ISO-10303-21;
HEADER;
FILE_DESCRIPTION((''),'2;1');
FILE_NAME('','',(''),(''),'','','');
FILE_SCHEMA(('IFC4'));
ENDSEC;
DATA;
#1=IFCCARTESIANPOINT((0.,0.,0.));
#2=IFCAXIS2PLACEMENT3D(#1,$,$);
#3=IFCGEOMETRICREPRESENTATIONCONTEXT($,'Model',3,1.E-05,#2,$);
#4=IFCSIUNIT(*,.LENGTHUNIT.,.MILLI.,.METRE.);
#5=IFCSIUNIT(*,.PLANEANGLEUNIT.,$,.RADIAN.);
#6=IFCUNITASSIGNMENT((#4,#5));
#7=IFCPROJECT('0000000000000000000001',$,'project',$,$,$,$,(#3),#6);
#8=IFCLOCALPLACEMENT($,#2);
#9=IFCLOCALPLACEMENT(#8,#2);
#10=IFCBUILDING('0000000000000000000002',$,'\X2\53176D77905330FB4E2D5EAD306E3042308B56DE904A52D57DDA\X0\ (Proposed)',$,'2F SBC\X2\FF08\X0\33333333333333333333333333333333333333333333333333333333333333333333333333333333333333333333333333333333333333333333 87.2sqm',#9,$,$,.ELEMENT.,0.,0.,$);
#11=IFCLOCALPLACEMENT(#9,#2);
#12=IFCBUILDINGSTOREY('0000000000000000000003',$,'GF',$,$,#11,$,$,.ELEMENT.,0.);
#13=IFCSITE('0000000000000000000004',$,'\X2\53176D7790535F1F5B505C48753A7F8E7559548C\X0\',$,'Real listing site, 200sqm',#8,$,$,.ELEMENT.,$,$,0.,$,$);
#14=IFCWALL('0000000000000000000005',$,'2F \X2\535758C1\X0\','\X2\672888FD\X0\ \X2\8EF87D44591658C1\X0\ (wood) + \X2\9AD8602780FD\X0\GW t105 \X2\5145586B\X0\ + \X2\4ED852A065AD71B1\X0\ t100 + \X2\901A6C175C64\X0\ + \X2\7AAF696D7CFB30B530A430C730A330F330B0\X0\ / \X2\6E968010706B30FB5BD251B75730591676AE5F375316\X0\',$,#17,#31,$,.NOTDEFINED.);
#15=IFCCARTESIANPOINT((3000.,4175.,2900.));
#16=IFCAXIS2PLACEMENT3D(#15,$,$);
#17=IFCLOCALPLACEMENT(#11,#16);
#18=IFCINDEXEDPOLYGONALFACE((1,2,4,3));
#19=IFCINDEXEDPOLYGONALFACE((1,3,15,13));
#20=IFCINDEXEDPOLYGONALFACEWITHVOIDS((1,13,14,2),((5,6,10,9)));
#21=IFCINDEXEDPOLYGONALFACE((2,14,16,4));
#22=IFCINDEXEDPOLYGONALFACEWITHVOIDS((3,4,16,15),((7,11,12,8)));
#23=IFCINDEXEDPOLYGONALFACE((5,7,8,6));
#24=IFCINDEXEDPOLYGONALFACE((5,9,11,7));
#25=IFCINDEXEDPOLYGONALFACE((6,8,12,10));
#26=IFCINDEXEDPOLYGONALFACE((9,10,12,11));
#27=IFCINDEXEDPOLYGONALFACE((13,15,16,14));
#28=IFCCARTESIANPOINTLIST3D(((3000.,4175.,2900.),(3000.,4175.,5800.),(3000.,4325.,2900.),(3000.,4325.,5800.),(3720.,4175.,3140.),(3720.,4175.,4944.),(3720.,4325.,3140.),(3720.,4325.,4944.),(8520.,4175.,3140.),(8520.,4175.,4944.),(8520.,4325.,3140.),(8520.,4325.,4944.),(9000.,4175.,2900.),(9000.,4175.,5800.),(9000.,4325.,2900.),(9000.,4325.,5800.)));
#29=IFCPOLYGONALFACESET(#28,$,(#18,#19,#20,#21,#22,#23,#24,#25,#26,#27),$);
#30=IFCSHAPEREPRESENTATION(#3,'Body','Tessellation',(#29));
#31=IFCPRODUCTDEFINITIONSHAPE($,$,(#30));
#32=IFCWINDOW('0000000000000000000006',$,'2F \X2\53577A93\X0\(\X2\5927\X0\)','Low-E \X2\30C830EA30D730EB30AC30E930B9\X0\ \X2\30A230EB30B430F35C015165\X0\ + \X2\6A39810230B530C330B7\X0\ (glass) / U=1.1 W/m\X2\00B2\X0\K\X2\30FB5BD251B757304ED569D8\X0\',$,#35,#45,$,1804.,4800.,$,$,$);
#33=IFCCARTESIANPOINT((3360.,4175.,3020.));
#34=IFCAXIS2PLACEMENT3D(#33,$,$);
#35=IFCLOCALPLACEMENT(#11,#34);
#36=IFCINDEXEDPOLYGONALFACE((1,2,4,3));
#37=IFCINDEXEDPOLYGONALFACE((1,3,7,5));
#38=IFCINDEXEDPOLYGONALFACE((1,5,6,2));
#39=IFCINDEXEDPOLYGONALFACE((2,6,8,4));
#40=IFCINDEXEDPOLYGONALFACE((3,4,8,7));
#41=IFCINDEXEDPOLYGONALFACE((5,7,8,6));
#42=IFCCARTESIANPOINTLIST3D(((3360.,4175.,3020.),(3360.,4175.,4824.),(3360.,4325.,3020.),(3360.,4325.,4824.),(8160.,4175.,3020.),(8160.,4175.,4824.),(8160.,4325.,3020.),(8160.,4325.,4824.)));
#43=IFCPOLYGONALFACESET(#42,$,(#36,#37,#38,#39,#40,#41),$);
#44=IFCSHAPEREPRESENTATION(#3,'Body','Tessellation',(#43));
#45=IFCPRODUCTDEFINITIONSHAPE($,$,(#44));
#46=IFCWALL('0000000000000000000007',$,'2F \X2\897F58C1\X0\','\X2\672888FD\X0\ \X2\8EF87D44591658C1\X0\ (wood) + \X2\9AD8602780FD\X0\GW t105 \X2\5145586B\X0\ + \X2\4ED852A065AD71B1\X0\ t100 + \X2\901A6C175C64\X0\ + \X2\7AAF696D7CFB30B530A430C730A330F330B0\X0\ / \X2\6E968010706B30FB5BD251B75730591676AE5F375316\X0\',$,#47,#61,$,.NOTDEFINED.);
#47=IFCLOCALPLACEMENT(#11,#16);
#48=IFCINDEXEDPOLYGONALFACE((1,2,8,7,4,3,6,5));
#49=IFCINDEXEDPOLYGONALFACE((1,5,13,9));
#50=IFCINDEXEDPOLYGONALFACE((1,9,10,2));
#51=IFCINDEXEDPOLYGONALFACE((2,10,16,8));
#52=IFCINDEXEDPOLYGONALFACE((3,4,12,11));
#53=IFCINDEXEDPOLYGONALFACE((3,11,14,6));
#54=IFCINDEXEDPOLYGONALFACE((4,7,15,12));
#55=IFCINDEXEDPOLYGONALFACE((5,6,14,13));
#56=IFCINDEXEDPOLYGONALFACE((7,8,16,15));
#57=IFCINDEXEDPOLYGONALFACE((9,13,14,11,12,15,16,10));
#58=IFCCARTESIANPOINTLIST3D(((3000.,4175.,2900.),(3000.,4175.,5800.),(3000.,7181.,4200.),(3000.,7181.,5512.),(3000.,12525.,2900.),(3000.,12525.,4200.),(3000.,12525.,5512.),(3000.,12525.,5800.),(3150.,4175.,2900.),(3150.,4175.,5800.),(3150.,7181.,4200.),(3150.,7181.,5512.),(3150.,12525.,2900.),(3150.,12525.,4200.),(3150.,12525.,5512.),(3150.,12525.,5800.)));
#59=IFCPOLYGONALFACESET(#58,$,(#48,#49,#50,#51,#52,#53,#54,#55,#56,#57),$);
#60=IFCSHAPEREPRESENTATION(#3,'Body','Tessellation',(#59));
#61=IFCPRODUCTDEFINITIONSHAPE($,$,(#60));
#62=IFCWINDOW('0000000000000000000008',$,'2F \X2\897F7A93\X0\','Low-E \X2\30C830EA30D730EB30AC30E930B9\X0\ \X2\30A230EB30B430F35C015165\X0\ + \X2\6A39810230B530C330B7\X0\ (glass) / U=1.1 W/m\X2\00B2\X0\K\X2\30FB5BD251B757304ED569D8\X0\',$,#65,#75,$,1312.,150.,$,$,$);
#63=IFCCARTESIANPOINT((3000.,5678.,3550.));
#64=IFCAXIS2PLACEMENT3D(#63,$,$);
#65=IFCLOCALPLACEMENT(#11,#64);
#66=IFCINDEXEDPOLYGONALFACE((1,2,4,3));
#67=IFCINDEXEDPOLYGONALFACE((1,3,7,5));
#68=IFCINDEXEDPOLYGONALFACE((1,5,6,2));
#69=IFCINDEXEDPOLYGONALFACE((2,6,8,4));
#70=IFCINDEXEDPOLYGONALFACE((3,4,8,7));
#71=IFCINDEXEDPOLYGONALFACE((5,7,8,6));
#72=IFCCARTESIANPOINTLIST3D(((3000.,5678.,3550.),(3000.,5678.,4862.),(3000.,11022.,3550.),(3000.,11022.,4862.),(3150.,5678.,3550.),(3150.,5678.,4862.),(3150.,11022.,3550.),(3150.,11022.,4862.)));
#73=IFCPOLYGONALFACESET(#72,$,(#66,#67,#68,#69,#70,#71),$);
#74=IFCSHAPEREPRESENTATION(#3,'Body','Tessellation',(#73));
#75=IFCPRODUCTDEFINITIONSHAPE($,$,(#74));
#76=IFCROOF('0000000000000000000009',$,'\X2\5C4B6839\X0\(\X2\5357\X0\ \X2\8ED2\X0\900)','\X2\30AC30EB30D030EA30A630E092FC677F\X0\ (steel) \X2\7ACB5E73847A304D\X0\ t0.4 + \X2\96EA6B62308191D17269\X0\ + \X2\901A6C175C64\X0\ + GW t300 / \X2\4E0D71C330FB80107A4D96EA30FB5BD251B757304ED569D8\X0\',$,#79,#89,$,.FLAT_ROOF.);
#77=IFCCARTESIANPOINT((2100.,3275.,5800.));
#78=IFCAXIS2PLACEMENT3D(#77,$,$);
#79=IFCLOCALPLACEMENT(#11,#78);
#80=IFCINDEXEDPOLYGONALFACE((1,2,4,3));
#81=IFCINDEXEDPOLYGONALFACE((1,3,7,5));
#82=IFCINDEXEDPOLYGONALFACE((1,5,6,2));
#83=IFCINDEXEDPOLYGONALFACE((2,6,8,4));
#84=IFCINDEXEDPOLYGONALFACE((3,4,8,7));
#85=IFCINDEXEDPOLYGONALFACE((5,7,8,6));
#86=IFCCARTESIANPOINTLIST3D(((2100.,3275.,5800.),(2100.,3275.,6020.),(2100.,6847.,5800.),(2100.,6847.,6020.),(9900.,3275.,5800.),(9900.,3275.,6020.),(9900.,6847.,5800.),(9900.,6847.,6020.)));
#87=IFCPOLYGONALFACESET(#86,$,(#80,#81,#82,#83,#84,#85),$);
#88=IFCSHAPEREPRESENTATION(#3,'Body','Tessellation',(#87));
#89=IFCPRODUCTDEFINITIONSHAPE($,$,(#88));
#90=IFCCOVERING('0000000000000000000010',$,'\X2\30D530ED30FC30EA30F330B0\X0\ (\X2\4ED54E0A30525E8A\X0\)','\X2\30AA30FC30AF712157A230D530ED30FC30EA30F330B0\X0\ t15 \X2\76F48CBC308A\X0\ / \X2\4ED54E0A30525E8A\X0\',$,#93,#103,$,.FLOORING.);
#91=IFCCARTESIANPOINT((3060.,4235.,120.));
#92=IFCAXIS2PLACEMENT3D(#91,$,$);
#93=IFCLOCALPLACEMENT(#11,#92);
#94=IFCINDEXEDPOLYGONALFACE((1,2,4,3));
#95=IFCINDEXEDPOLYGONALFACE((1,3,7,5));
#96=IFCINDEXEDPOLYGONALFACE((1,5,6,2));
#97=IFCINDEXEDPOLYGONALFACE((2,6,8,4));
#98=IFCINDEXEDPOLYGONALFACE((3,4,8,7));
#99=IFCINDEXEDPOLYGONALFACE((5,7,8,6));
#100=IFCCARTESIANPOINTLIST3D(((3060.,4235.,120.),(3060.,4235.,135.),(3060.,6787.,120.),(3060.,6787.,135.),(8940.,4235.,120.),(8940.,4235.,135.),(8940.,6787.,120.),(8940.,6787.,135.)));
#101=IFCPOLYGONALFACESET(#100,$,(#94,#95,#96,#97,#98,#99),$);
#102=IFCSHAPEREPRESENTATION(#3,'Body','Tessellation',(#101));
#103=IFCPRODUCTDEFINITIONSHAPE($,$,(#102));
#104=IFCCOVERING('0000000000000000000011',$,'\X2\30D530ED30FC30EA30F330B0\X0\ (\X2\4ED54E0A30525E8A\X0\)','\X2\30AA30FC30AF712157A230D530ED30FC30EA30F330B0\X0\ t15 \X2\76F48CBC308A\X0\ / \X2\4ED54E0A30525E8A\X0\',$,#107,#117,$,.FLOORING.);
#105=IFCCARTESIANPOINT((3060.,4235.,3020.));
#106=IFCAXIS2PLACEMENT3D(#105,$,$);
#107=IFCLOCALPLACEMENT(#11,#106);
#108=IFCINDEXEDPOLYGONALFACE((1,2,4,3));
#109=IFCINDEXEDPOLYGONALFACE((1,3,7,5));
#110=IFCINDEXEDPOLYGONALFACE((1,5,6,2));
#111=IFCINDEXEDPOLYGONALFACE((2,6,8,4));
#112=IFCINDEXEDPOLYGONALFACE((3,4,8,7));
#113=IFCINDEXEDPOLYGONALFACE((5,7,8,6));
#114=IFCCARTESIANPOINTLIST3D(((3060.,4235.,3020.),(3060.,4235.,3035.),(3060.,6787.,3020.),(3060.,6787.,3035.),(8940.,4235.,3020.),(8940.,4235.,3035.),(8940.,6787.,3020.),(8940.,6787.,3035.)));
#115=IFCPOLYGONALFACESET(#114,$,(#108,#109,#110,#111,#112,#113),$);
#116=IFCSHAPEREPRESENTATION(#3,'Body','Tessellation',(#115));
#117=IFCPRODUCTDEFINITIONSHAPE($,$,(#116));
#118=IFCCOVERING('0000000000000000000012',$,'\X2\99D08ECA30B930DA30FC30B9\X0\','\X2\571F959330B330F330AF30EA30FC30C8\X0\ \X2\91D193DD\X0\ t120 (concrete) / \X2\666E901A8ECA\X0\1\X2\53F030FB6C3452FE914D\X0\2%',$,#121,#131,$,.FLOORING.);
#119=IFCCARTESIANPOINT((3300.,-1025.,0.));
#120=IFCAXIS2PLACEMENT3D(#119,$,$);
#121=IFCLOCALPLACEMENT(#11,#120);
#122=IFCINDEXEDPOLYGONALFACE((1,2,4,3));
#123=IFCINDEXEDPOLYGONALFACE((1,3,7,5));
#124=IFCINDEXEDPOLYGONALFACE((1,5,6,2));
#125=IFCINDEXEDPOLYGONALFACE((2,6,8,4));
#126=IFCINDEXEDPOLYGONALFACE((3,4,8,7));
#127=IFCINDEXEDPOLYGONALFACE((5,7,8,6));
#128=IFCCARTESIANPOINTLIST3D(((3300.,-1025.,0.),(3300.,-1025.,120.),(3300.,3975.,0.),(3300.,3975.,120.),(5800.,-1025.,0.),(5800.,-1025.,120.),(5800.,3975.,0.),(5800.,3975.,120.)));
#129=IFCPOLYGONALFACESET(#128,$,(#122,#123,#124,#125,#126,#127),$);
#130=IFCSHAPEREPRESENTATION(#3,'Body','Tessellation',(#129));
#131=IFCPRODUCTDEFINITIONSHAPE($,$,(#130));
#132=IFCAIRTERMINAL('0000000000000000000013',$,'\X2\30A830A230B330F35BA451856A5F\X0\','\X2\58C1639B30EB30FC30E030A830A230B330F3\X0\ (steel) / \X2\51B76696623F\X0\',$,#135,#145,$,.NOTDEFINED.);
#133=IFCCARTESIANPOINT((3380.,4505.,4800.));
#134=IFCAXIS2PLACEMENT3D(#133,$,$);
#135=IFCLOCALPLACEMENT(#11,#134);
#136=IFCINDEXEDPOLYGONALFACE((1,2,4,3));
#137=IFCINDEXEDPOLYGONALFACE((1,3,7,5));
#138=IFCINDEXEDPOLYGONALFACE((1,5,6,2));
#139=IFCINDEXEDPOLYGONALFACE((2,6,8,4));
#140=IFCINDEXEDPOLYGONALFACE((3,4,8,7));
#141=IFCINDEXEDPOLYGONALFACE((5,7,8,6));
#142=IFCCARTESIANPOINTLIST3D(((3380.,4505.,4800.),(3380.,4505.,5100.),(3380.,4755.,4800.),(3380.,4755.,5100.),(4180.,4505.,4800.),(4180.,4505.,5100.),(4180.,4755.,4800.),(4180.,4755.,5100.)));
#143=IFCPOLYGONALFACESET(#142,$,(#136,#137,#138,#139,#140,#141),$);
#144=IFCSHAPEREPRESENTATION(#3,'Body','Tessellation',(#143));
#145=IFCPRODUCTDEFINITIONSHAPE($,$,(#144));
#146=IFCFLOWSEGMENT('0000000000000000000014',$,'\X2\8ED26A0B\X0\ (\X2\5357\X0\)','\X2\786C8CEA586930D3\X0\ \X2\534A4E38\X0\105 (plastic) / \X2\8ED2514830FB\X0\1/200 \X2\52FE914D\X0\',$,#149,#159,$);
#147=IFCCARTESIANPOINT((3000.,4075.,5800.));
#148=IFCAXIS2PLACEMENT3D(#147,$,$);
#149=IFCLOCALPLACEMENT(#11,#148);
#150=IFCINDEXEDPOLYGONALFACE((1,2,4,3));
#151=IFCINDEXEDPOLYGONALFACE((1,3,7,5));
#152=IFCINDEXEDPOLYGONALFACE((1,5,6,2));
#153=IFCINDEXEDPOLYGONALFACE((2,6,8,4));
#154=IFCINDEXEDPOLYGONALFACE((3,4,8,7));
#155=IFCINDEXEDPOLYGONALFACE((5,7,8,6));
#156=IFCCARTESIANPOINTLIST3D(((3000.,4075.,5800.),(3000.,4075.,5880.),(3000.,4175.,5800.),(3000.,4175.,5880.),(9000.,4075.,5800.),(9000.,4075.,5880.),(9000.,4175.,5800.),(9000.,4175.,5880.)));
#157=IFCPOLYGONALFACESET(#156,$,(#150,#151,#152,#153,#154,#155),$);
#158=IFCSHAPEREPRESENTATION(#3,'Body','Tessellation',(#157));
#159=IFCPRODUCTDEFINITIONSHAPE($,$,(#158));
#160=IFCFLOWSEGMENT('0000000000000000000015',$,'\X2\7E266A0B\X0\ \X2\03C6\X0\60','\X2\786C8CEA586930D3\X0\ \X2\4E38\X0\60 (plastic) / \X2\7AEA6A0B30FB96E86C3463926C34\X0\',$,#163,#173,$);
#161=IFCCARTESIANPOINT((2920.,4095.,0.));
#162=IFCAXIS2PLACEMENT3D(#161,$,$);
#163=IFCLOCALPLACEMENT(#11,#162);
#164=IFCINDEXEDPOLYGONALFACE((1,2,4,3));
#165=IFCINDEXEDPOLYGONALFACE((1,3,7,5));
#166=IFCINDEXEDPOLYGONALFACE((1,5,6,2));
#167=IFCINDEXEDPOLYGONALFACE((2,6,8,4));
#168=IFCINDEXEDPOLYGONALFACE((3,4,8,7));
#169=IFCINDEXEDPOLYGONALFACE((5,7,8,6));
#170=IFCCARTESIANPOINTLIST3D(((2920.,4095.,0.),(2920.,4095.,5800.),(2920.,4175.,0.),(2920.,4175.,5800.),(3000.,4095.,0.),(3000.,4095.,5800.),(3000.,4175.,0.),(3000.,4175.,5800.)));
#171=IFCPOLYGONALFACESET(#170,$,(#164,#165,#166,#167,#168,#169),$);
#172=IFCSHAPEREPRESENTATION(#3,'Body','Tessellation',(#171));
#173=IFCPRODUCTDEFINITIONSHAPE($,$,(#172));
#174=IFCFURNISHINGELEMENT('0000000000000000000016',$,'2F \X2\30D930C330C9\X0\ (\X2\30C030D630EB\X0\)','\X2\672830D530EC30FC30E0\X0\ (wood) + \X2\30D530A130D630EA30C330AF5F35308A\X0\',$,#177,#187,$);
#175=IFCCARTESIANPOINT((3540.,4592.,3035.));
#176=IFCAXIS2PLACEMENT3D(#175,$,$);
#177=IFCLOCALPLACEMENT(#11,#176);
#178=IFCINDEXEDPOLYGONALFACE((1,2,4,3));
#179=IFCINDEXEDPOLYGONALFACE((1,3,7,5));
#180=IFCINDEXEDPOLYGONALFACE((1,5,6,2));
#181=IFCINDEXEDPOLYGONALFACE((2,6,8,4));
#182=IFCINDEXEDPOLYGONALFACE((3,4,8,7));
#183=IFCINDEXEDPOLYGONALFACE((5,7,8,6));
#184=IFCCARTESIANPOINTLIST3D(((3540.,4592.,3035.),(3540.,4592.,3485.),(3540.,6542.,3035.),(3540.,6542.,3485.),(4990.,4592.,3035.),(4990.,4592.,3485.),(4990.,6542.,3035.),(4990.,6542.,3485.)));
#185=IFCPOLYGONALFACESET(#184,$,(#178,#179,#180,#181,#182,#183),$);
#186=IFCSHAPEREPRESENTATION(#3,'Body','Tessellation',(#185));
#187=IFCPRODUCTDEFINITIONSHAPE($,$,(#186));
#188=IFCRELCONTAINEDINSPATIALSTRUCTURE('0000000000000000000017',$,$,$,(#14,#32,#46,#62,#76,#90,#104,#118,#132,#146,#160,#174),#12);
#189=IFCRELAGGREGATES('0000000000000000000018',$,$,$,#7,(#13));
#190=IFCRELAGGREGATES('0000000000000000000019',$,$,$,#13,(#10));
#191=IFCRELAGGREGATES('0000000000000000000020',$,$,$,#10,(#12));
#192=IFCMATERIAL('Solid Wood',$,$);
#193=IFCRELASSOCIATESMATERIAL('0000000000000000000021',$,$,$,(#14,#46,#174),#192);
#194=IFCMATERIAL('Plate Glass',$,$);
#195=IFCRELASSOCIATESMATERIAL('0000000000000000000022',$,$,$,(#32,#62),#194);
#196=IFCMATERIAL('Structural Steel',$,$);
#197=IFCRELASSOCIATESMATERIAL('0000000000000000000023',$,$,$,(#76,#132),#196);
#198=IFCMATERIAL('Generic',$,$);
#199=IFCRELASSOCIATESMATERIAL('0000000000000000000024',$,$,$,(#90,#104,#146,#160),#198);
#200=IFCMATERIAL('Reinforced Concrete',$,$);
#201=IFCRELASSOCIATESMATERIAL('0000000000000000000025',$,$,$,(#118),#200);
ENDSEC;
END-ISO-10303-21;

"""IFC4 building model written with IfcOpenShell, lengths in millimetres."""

from ifc_helpers import new_model, si_unit, frame, frame_2d, origin, place, context, project, spatial, rectangle, extrude, material, element, fill, save


model = new_model("IFC4")

# Units and contexts
model_context = context("Model", 3, precision=1e-05, world=origin())
ifc_project = project(units=[si_unit("LENGTHUNIT", "METRE", prefix="MILLI"), si_unit("PLANEANGLEUNIT", "RADIAN")], contexts=[model_context])

# Site, building, storey
site_placement = place(None, origin())
site = spatial("IfcSite", under=ifc_project, at=site_placement, Name="北海道弟子屈町美留和", ObjectType="Real listing site, 200sqm", CompositionType="ELEMENT", RefElevation=0.0)
building_placement = place(site_placement, origin())
building = spatial("IfcBuilding", under=site, at=building_placement, Name="北海道・中庭のある回遊動線 (Proposed)", ObjectType="2F SBC（33333333333333333333333333333333333333333333333333333333333333333333333333333333333333333333333333333333333333333333 87.2sqm", CompositionType="ELEMENT", ElevationOfRefHeight=0.0, ElevationOfTerrain=0.0)
storey_placement = place(building_placement, origin())
storey = spatial("IfcBuildingStorey", under=building, at=storey_placement, Name="GF", CompositionType="ELEMENT", Elevation=0.0)

# Shared definitions
ifc_material_1 = material(Name="Solid Wood")

# Shared definitions
ifc_material_2 = material(Name="Reinforced Concrete")

# Shared definitions
ifc_material_3 = material(Name="Plate Glass")

# Walls, openings, windows
wall_1_placement = place(storey_placement, frame((3000.0, 4175.0, 2900.0)))
wall_1 = element("IfcWall", 1, at=wall_1_placement, inside=storey, material=ifc_material_1, Name="2F 南壁", Description="木製 軸組外壁 (wood) + 高性能GW t105 充填 + 付加断熱 t100 + 通気層 + 窯業系サイディング / 準耐火・寒冷地外皮強化", PredefinedType="NOTDEFINED", context=model_context, shape_type="SweptSolid", body=[
    extrude(rectangle(XDim=6000.0, YDim=150.0, at=frame_2d((3000.0, 75.0))), frame((3000.0, 4175.0, 2900.0)), (0.0, 0.0, 1.0), 2900.0),
])
opening_1_placement = place(storey_placement, frame((3360.0, 4175.0, 3020.0)))
opening_1 = element("IfcOpeningElement", 2, at=opening_1_placement, cuts=wall_1, PredefinedType="NOTDEFINED", context=model_context, shape_type="SweptSolid", body=[
    extrude(rectangle(XDim=4800.0, YDim=150.0, at=frame_2d((2400.0, 75.0))), frame((3360.0, 4175.0, 3020.0)), (0.0, 0.0, 1.0), 1804.0),
])
window_1_placement = place(storey_placement, frame((3360.0, 4175.0, 3020.0)))
window_1 = element("IfcWindow", 3, at=window_1_placement, inside=storey, material=ifc_material_3, Name="2F 南窓(大)", Description="Low-E トリプルガラス アルゴン封入 + 樹脂サッシ (glass) / U=1.1 W/m²K・寒冷地仕様", OverallHeight=1804.0, OverallWidth=4800.0, context=model_context, shape_type="SweptSolid", body=[
    extrude(rectangle(XDim=4800.0, YDim=150.0, at=frame_2d((2400.0, 75.0))), frame((3360.0, 4175.0, 3020.0)), (0.0, 0.0, 1.0), 1804.0),
])
fill(opening_1, window_1)
wall_2_placement = place(storey_placement, frame((3000.0, 4175.0, 2900.0)))
wall_2 = element("IfcWall", 4, at=wall_2_placement, inside=storey, material=ifc_material_1, Name="2F 西壁", Description="木製 軸組外壁 (wood) + 高性能GW t105 充填 + 付加断熱 t100 + 通気層 + 窯業系サイディング / 準耐火・寒冷地外皮強化", PredefinedType="NOTDEFINED", context=model_context, shape_type="SweptSolid", body=[
    extrude(rectangle(XDim=150.0, YDim=8350.0, at=frame_2d((75.0, 4175.0))), frame((3000.0, 4175.0, 2900.0)), (0.0, 0.0, 1.0), 2900.0),
])
opening_2_placement = place(storey_placement, frame((3000.0, 5678.0, 3550.0)))
opening_2 = element("IfcOpeningElement", 5, at=opening_2_placement, cuts=wall_2, PredefinedType="NOTDEFINED", context=model_context, shape_type="SweptSolid", body=[
    extrude(rectangle(XDim=150.0, YDim=5344.0, at=frame_2d((75.0, 2672.0))), frame((3000.0, 5678.0, 3550.0)), (0.0, 0.0, 1.0), 1312.0),
])
window_2_placement = place(storey_placement, frame((3000.0, 5678.0, 3550.0)))
window_2 = element("IfcWindow", 6, at=window_2_placement, inside=storey, material=ifc_material_3, Name="2F 西窓", Description="Low-E トリプルガラス アルゴン封入 + 樹脂サッシ (glass) / U=1.1 W/m²K・寒冷地仕様", OverallHeight=1312.0, OverallWidth=150.0, context=model_context, shape_type="SweptSolid", body=[
    extrude(rectangle(XDim=150.0, YDim=5344.0, at=frame_2d((75.0, 2672.0))), frame((3000.0, 5678.0, 3550.0)), (0.0, 0.0, 1.0), 1312.0),
])
fill(opening_2, window_2)

# Roof
ifc_material_4 = material(Name="Structural Steel")
for number, where, name in (
    (7, (2100.0, 3275.0, 5800.0), "屋根(南 軒900)"),
):
    element("IfcRoof", number, at=place(storey_placement, frame(where)), inside=storey, material=ifc_material_4, Name=name, Description="ガルバリウム鋼板 (steel) 立平葺き t0.4 + 雪止め金物 + 通気層 + GW t300 / 不燃・耐積雪・寒冷地仕様", PredefinedType="FLAT_ROOF", context=model_context, shape_type="SweptSolid", body=[
        extrude(rectangle(XDim=7800.0, YDim=3572.0, at=frame_2d((3900.0, 1786.0))), frame((2100.0, 3275.0, 5800.0)), (0.0, 0.0, 1.0), 220.0),
    ])

# Coverings
ifc_material_5 = material(Name="Generic")
covering_1_placement = place(storey_placement, frame((3060.0, 4235.0, 120.0)))
element("IfcCovering", 8, at=covering_1_placement, inside=storey, material=ifc_material_5, Name="フローリング (仕上げ床)", Description="オーク無垢フローリング t15 直貼り / 仕上げ床", PredefinedType="FLOORING", context=model_context, shape_type="SweptSolid", body=[
    extrude(rectangle(XDim=5880.0, YDim=2552.0, at=frame_2d((2940.0, 1276.0))), frame((3060.0, 4235.0, 120.0)), (0.0, 0.0, 1.0), 15.0),
])
covering_2_placement = place(storey_placement, frame((3060.0, 4235.0, 3020.0)))
element("IfcCovering", 9, at=covering_2_placement, inside=storey, material=ifc_material_5, Name="フローリング (仕上げ床)", Description="オーク無垢フローリング t15 直貼り / 仕上げ床", PredefinedType="FLOORING", context=model_context, shape_type="SweptSolid", body=[
    extrude(rectangle(XDim=5880.0, YDim=2552.0, at=frame_2d((2940.0, 1276.0))), frame((3060.0, 4235.0, 3020.0)), (0.0, 0.0, 1.0), 15.0),
])
covering_3_placement = place(storey_placement, frame((3300.0, -1025.0, 0.0)))
element("IfcCovering", 10, at=covering_3_placement, inside=storey, material=ifc_material_2, Name="駐車スペース", Description="土間コンクリート 金鏝 t120 (concrete) / 普通車1台・水勾配2%", PredefinedType="FLOORING", context=model_context, shape_type="SweptSolid", body=[
    extrude(rectangle(XDim=2500.0, YDim=5000.0, at=frame_2d((1250.0, 2500.0))), frame((3300.0, -1025.0, 0.0)), (0.0, 0.0, 1.0), 120.0),
])

# Air terminal
air_terminal_placement = place(storey_placement, frame((3380.0, 4505.0, 4800.0)))
element("IfcAirTerminal", 11, at=air_terminal_placement, inside=storey, material=ifc_material_4, Name="エアコン室内機", Description="壁掛ルームエアコン (steel) / 冷暖房", PredefinedType="NOTDEFINED", context=model_context, shape_type="SweptSolid", body=[
    extrude(rectangle(XDim=800.0, YDim=250.0, at=frame_2d((400.0, 125.0))), frame((3380.0, 4505.0, 4800.0)), (0.0, 0.0, 1.0), 300.0),
])

# Flow segments
flow_segment_1_placement = place(storey_placement, frame((3000.0, 4075.0, 5800.0)))
element("IfcFlowSegment", 12, at=flow_segment_1_placement, inside=storey, material=ifc_material_5, Name="軒樋 (南)", Description="硬質塩ビ 半丸105 (plastic) / 軒先・1/200 勾配", context=model_context, shape_type="SweptSolid", body=[
    extrude(rectangle(XDim=6000.0, YDim=100.0, at=frame_2d((3000.0, 50.0))), frame((3000.0, 4075.0, 5800.0)), (0.0, 0.0, 1.0), 80.0),
])
flow_segment_2_placement = place(storey_placement, frame((2920.0, 4095.0, 0.0)))
element("IfcFlowSegment", 13, at=flow_segment_2_placement, inside=storey, material=ifc_material_5, Name="縦樋 φ60", Description="硬質塩ビ 丸60 (plastic) / 竪樋・雨水排水", context=model_context, shape_type="SweptSolid", body=[
    extrude(rectangle(XDim=80.0, YDim=80.0, at=frame_2d((40.0, 40.0))), frame((2920.0, 4095.0, 0.0)), (0.0, 0.0, 1.0), 5800.0),
])

# Furnishing element
furnishing_placement = place(storey_placement, frame((3540.0, 4592.0, 3035.0)))
element("IfcFurnishingElement", 14, at=furnishing_placement, inside=storey, material=ifc_material_1, Name="2F ベッド (ダブル)", Description="木フレーム (wood) + ファブリック張り", context=model_context, shape_type="SweptSolid", body=[
    extrude(rectangle(XDim=1450.0, YDim=1950.0, at=frame_2d((725.0, 975.0))), frame((3540.0, 4592.0, 3035.0)), (0.0, 0.0, 1.0), 450.0),
])

save(model, "model.ifc")
